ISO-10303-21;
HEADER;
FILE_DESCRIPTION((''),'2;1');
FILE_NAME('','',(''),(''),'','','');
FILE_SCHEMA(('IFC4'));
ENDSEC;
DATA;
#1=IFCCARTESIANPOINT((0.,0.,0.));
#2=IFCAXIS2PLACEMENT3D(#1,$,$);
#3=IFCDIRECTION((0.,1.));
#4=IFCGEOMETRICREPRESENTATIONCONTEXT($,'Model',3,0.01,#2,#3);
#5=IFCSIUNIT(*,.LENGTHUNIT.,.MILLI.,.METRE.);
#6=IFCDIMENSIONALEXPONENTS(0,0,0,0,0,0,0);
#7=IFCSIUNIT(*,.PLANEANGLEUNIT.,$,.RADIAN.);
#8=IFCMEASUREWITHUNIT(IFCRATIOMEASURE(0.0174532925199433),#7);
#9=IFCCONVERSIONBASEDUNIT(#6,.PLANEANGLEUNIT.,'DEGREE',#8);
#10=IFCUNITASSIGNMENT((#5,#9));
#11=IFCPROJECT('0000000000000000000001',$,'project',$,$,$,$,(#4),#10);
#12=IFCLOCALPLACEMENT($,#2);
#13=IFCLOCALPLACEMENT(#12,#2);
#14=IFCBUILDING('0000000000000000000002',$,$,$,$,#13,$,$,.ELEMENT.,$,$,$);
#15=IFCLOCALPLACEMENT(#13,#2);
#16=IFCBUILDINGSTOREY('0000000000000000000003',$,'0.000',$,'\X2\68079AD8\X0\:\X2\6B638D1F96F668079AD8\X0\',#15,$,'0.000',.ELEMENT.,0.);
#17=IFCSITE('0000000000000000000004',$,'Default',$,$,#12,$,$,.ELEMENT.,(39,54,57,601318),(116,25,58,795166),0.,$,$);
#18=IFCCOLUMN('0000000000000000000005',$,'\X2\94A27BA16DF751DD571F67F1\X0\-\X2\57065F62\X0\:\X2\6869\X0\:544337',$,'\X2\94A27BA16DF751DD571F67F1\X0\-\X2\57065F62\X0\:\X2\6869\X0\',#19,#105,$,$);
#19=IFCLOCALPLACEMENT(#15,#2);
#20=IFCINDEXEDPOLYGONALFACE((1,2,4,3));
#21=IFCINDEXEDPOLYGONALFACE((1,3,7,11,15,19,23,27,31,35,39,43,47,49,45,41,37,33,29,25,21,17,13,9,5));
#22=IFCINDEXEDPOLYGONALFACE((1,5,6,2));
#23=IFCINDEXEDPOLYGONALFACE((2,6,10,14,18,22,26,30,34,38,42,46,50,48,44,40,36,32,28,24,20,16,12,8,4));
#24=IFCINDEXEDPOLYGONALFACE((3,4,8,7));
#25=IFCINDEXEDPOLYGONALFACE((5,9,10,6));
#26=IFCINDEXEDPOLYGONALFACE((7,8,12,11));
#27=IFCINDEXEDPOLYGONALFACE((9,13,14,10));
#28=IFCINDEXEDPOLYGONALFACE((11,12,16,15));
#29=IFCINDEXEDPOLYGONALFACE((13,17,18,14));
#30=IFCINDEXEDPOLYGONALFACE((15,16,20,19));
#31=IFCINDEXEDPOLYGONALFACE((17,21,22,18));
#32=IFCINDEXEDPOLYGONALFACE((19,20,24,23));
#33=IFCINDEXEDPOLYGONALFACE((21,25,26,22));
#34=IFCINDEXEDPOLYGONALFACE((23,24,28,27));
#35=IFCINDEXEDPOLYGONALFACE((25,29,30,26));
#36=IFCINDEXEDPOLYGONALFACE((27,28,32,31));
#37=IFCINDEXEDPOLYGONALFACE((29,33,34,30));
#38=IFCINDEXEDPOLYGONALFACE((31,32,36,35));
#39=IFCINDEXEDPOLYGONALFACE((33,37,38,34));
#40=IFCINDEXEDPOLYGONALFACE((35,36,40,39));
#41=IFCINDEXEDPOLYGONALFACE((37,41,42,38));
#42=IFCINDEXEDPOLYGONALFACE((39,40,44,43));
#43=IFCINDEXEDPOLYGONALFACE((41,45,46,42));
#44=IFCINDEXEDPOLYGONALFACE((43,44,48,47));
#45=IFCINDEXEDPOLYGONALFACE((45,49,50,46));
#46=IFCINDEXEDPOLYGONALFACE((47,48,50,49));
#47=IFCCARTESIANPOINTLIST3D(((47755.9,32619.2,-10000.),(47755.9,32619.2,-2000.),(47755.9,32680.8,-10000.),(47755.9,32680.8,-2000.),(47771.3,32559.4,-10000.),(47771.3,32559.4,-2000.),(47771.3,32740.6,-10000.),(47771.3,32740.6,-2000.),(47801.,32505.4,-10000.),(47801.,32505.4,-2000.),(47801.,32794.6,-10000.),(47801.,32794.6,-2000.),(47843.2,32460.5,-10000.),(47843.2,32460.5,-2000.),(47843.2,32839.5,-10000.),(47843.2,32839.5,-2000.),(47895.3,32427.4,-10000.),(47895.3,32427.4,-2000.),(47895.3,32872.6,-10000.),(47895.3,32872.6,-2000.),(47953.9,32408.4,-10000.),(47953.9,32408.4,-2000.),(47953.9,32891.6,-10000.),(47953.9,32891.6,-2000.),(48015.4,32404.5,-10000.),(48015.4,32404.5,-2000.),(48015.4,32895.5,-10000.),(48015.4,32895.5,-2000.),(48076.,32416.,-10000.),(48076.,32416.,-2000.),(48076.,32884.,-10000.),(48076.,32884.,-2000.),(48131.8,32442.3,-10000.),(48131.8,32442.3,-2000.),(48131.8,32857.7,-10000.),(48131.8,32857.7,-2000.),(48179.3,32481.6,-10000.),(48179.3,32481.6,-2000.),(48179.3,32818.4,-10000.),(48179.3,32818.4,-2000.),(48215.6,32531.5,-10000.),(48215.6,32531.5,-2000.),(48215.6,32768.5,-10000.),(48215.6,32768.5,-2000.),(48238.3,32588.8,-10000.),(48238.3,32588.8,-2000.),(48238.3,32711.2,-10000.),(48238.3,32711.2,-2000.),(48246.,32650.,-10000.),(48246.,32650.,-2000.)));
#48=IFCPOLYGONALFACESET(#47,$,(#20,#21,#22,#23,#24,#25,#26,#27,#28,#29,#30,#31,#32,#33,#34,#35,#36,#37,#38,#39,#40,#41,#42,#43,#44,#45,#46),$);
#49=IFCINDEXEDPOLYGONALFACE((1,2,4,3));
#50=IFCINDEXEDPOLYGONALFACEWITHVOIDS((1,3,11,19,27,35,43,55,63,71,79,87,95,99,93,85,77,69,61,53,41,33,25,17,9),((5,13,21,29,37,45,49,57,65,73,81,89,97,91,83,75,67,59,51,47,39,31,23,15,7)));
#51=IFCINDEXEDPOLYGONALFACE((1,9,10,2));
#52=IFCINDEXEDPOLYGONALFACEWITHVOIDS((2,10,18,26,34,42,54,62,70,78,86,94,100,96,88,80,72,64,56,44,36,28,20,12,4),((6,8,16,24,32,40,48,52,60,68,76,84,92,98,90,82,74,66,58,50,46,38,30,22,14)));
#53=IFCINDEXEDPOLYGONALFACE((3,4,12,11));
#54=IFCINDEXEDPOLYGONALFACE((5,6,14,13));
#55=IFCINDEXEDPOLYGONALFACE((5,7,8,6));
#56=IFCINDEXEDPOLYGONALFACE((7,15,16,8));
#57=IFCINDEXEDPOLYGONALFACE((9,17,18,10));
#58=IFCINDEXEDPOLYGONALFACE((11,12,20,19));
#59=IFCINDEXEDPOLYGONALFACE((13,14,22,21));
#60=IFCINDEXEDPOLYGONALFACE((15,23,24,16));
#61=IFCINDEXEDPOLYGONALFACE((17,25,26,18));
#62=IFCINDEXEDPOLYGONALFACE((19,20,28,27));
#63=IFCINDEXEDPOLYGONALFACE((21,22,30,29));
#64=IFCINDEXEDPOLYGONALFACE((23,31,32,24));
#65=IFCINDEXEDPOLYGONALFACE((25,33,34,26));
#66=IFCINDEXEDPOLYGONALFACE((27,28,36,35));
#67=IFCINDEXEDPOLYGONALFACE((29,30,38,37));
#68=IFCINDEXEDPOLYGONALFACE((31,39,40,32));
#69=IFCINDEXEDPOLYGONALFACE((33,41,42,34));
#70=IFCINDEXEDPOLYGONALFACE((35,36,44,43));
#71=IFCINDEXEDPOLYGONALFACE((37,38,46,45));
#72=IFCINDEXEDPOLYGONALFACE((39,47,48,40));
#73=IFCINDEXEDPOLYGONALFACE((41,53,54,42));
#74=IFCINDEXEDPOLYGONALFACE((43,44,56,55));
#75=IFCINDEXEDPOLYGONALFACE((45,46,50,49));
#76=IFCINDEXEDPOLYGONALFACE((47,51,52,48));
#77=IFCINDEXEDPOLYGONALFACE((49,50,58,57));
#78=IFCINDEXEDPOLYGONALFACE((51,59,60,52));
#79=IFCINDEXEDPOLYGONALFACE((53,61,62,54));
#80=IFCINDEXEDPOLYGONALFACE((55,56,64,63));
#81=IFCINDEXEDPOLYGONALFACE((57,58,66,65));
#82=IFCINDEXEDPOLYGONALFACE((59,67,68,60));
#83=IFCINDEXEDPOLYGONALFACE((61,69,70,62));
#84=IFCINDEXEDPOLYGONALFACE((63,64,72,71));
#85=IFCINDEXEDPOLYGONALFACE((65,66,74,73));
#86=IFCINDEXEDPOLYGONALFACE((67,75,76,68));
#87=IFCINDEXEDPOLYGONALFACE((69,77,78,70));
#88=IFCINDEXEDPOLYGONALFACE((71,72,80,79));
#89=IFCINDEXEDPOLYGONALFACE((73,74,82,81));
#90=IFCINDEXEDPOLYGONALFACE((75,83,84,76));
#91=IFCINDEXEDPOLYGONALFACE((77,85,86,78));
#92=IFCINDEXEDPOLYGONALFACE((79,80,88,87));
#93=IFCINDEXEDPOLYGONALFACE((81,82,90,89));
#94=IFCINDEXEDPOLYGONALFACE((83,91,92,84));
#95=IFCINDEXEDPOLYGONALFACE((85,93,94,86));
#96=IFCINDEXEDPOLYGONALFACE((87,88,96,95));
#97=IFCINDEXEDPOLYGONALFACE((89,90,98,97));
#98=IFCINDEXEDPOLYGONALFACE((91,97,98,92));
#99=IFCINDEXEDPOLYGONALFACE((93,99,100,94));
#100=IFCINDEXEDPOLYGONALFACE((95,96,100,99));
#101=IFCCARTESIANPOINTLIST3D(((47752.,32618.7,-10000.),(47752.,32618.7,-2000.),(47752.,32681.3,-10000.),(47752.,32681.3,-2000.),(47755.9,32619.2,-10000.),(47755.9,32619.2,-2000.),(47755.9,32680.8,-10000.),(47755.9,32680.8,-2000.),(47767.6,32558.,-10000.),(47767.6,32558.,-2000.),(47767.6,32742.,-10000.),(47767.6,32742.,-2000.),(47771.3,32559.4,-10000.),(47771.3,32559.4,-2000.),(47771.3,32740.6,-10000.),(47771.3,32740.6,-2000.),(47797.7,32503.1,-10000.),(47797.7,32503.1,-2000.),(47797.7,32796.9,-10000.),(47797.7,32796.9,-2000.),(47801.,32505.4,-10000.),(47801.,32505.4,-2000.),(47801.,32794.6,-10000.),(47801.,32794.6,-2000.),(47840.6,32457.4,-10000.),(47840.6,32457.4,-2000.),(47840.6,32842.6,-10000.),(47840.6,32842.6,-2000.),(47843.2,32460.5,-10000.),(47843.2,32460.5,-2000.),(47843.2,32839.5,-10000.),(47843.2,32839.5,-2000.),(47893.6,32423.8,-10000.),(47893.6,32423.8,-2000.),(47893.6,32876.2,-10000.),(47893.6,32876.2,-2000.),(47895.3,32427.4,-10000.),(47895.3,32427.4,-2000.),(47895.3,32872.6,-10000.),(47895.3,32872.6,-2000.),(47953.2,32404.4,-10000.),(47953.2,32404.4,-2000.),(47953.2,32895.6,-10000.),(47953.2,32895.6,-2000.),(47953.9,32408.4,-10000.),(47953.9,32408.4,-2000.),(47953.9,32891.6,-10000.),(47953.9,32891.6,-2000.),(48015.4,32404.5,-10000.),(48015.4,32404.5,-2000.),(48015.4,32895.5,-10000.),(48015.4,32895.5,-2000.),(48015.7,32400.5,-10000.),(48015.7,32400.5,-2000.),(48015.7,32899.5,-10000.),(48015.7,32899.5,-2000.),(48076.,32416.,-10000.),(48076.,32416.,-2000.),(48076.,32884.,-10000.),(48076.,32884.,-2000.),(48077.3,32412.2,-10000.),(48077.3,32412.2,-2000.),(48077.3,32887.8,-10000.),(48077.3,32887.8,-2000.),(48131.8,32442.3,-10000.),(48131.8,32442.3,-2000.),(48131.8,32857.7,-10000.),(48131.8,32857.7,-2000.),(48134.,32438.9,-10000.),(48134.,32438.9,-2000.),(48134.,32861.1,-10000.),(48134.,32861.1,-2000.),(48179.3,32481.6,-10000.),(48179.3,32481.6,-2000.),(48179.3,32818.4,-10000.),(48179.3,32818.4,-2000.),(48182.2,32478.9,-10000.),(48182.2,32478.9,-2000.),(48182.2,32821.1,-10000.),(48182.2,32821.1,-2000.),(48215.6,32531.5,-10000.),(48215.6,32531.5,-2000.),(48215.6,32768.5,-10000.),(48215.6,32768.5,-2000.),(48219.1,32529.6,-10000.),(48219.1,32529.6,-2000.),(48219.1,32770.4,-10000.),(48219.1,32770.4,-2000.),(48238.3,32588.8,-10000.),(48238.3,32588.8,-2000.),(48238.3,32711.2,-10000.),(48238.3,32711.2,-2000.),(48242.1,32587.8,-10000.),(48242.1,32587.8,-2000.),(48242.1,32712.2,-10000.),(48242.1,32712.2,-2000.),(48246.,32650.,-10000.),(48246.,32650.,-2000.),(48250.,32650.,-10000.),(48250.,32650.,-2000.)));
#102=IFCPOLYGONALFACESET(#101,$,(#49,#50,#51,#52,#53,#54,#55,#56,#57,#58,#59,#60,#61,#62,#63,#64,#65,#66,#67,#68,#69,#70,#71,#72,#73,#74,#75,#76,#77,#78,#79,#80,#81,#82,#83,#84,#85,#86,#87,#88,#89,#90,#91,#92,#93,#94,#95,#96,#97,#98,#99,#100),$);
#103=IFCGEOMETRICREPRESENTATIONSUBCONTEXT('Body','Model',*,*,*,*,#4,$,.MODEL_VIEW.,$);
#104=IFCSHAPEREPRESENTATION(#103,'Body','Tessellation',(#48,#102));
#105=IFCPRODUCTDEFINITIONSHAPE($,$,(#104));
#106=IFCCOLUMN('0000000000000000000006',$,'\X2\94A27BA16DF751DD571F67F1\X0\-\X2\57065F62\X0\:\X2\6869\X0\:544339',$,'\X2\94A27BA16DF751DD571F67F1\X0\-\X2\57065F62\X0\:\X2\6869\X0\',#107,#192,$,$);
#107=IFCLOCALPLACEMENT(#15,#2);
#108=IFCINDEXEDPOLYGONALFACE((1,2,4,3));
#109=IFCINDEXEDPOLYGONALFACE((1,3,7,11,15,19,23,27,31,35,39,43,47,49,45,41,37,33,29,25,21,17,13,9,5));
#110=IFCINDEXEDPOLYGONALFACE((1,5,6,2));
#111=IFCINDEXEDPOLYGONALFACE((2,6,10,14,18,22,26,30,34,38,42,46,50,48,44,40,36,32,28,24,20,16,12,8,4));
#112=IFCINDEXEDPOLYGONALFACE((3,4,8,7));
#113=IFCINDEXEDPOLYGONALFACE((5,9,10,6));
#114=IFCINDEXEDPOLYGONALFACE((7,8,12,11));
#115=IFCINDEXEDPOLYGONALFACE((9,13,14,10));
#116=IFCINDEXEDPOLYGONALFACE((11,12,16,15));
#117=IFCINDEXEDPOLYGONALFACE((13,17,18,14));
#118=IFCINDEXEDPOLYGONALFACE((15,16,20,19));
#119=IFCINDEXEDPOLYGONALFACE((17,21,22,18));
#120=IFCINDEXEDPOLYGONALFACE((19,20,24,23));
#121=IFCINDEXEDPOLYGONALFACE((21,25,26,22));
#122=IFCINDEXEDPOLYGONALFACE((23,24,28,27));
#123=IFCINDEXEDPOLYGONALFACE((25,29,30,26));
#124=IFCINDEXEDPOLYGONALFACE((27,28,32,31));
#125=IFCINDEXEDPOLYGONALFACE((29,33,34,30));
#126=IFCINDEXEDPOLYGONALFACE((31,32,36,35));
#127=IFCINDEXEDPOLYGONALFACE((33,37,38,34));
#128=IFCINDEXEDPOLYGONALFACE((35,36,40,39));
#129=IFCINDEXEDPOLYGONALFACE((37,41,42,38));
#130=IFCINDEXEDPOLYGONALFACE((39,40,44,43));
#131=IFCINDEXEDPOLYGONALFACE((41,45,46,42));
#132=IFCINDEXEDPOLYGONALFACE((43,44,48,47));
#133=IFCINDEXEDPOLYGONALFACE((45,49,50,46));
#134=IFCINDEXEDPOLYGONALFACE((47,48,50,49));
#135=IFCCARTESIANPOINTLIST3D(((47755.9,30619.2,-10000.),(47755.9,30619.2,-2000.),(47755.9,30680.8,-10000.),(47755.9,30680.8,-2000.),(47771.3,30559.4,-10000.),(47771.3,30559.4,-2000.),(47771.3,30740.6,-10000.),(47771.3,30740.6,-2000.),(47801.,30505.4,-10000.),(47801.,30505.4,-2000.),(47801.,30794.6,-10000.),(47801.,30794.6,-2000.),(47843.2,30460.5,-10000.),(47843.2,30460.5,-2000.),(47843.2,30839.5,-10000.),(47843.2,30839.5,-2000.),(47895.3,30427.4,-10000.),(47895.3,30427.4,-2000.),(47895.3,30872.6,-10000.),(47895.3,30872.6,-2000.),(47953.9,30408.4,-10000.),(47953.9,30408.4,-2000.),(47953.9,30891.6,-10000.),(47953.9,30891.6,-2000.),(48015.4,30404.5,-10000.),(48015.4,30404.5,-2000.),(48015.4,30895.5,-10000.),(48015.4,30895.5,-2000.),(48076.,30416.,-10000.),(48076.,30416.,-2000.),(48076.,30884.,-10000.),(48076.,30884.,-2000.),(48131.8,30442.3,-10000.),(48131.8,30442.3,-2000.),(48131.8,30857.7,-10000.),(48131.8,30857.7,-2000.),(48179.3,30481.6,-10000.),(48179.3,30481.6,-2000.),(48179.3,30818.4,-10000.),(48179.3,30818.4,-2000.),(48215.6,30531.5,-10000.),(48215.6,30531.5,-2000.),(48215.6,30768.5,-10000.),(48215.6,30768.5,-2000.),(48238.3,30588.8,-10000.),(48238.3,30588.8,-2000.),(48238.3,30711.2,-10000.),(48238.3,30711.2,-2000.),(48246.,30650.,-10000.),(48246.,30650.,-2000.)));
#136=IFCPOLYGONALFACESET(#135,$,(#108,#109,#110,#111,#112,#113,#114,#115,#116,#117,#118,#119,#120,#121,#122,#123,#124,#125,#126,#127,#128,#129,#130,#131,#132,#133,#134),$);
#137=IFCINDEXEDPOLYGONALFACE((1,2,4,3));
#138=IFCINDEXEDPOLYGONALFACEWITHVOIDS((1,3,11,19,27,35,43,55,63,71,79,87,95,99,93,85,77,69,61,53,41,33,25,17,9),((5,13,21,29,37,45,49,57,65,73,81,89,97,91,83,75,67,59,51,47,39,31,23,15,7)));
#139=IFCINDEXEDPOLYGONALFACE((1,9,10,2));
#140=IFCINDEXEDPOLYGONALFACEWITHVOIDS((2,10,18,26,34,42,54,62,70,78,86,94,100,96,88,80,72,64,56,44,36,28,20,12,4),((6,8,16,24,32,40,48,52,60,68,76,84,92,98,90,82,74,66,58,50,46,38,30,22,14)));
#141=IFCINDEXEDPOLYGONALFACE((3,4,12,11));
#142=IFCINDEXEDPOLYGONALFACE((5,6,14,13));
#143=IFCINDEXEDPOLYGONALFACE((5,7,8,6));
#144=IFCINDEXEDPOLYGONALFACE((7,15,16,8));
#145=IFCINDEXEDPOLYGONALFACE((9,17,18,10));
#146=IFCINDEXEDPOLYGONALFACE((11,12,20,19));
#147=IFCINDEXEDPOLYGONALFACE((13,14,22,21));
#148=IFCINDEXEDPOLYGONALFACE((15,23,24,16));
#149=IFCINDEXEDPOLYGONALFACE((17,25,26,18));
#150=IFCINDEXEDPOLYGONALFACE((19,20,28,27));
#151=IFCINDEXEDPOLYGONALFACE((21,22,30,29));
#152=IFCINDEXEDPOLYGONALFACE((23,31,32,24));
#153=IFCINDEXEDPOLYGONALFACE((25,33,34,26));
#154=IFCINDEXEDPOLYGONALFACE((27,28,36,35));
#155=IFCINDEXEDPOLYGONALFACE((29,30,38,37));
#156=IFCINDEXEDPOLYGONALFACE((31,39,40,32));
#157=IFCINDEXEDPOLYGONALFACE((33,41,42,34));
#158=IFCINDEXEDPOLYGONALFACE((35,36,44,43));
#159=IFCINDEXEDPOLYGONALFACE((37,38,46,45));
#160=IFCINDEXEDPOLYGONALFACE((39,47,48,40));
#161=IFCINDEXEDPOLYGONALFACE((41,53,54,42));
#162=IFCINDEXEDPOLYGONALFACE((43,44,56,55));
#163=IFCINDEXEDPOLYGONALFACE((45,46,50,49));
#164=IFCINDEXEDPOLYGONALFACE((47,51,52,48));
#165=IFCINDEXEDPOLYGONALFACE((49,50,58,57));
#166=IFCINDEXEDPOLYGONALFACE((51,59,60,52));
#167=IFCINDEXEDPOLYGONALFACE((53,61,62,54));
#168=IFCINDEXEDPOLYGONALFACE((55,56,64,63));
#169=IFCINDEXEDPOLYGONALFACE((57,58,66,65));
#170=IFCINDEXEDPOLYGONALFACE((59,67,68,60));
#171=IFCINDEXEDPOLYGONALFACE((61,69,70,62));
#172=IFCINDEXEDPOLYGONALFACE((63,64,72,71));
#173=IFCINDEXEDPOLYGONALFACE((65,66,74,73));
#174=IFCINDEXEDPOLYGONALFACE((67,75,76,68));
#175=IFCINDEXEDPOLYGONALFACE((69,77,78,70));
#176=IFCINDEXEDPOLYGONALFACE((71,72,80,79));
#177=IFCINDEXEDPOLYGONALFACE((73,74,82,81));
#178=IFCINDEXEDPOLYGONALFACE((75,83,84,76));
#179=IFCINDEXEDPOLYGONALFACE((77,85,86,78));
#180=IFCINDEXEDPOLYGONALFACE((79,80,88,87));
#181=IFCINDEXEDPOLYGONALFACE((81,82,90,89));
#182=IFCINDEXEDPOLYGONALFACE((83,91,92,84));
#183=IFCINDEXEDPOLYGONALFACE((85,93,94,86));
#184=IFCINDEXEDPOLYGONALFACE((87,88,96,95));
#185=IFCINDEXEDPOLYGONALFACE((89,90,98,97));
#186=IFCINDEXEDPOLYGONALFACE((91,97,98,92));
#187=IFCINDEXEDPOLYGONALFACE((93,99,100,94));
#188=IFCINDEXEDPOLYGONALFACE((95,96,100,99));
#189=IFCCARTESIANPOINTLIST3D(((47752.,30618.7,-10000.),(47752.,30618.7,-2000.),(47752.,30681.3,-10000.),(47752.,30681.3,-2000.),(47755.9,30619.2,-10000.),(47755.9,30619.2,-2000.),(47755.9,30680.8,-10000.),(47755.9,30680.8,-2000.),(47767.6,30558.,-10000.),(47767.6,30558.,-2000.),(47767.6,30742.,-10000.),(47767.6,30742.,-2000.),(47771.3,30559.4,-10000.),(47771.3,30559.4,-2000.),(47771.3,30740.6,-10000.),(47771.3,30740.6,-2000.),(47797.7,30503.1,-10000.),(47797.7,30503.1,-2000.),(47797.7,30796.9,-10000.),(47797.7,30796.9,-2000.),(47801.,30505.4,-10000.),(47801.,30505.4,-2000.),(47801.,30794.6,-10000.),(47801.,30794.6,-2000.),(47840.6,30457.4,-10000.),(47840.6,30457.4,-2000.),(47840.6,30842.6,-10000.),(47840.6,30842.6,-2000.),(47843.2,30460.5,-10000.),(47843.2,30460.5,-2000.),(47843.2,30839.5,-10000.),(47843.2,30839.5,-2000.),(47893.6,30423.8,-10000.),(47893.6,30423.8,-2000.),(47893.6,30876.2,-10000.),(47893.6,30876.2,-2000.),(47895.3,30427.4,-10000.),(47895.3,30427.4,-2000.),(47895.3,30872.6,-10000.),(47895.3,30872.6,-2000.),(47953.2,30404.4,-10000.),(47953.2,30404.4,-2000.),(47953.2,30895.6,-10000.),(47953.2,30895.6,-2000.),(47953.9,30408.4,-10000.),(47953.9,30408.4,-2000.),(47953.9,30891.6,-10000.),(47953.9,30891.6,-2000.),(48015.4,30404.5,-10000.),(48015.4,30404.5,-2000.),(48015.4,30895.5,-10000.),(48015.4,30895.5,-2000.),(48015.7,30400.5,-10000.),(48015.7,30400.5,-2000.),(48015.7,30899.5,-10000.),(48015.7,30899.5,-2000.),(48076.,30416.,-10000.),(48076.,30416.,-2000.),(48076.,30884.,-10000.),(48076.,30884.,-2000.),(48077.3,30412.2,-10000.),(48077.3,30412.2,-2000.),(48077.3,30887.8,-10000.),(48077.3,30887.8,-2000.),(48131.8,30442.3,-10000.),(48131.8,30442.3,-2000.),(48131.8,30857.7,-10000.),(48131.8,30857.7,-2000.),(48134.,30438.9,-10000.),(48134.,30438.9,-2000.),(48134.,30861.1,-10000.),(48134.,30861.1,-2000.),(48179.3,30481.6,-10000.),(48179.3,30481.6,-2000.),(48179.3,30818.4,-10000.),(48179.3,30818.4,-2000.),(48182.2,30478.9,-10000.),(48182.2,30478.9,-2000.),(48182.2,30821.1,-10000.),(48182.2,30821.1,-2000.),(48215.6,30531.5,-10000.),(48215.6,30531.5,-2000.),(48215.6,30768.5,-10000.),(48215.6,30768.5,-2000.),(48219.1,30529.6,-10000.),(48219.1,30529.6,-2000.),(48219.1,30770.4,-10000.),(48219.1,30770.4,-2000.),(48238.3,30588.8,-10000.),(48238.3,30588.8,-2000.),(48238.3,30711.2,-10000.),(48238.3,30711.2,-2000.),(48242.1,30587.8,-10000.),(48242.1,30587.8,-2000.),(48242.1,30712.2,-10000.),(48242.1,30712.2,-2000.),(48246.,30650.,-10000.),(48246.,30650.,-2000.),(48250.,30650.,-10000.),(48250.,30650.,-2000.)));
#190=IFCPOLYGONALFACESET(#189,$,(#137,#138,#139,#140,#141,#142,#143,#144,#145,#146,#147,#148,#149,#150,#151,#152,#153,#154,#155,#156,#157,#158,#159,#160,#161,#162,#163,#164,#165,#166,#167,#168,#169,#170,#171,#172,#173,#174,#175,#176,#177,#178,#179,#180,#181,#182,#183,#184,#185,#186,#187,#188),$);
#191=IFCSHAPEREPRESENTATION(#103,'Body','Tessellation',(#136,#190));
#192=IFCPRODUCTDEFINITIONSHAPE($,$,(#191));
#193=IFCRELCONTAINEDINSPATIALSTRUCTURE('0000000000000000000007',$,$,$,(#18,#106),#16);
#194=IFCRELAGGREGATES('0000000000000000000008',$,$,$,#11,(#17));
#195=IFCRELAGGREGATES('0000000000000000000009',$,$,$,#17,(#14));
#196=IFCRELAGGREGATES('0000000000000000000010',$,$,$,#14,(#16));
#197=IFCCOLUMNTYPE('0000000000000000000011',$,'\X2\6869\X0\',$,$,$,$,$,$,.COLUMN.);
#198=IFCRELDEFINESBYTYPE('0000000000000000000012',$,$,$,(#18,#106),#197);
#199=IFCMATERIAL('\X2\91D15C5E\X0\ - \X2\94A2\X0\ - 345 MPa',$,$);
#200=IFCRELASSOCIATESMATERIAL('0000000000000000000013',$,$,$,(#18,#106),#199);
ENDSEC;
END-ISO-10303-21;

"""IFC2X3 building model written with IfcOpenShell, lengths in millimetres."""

from ifc_helpers import new_model, entity, si_unit, converted_unit, direction, frame, frame_2d, origin, place, context, subcontext, project, spatial, circle, hollow_circle, extrude, source, transform, mapped, material, type_object, type_shapes, element, save


model = new_model("IFC2X3")

# Units and contexts
model_context = context("Model", 3, precision=0.01, world=origin(), true_north=direction((0.0, 1.0)))
body_context = subcontext(model_context, "Body", "Model", "MODEL_VIEW")
ifc_project = project(units=[si_unit("LENGTHUNIT", "METRE", prefix="MILLI"), converted_unit("PLANEANGLEUNIT", "DEGREE", entity("IfcRatioMeasure", 0.0174532925199433), si_unit("PLANEANGLEUNIT", "RADIAN"), dimensions=[0, 0, 0, 0, 0, 0, 0])], contexts=[model_context])

# Site, building, storey
site_placement = place(None, origin())
site = spatial("IfcSite", under=ifc_project, at=site_placement, Name="Default", CompositionType="ELEMENT", RefLatitude=(39, 54, 57, 601318), RefLongitude=(116, 25, 58, 795166), RefElevation=0.0)
building_placement = place(site_placement, origin())
building = spatial("IfcBuilding", under=site, at=building_placement, CompositionType="ELEMENT")
storey_placement = place(building_placement, origin())
storey = spatial("IfcBuildingStorey", under=building, at=storey_placement, Name="0.000", ObjectType="标高:正负零标高", LongName="0.000", CompositionType="ELEMENT", Elevation=0.0)

# Columns
ifc_material_1 = material(Name="金属 - 钢 - 345 MPa")
column_type_1 = type_object("IfcColumnType", Name="桩", PredefinedType="COLUMN")
shared_shape_1 = source(origin(), body_context, "Body", "SweptSolid", [
    extrude(circle(Radius=246.0, at=frame_2d((0.0, 0.0), x_axis=(1.0, 0.0))), frame((0.0, 0.0, -10000.0)), (0.0, 0.0, 1.0), 8000.0),
    extrude(hollow_circle(Radius=250.0, WallThickness=4.0, at=frame_2d((0.0, 0.0), x_axis=(1.0, 0.0))), frame((0.0, 0.0, -10000.0)), (0.0, 0.0, 1.0), 8000.0),
])
type_shapes(column_type_1, [shared_shape_1])
for number, where, name in (
    (1, (48000.0, 32650.0, 0.0), "钢管混凝土柱-圆形:桩:544337"),
    (2, (48000.0, 30650.0, 0.0), "钢管混凝土柱-圆形:桩:544339"),
):
    element("IfcColumn", number, at=place(storey_placement, frame(where)), inside=storey, type_object=column_type_1, material=ifc_material_1, Name=name, ObjectType="钢管混凝土柱-圆形:桩", context=body_context, shape_type="MappedRepresentation", body=[
        mapped(shared_shape_1, transform((0.0, 0.0, 0.0), scale=1.0)),
    ])

save(model, "model.ifc")
